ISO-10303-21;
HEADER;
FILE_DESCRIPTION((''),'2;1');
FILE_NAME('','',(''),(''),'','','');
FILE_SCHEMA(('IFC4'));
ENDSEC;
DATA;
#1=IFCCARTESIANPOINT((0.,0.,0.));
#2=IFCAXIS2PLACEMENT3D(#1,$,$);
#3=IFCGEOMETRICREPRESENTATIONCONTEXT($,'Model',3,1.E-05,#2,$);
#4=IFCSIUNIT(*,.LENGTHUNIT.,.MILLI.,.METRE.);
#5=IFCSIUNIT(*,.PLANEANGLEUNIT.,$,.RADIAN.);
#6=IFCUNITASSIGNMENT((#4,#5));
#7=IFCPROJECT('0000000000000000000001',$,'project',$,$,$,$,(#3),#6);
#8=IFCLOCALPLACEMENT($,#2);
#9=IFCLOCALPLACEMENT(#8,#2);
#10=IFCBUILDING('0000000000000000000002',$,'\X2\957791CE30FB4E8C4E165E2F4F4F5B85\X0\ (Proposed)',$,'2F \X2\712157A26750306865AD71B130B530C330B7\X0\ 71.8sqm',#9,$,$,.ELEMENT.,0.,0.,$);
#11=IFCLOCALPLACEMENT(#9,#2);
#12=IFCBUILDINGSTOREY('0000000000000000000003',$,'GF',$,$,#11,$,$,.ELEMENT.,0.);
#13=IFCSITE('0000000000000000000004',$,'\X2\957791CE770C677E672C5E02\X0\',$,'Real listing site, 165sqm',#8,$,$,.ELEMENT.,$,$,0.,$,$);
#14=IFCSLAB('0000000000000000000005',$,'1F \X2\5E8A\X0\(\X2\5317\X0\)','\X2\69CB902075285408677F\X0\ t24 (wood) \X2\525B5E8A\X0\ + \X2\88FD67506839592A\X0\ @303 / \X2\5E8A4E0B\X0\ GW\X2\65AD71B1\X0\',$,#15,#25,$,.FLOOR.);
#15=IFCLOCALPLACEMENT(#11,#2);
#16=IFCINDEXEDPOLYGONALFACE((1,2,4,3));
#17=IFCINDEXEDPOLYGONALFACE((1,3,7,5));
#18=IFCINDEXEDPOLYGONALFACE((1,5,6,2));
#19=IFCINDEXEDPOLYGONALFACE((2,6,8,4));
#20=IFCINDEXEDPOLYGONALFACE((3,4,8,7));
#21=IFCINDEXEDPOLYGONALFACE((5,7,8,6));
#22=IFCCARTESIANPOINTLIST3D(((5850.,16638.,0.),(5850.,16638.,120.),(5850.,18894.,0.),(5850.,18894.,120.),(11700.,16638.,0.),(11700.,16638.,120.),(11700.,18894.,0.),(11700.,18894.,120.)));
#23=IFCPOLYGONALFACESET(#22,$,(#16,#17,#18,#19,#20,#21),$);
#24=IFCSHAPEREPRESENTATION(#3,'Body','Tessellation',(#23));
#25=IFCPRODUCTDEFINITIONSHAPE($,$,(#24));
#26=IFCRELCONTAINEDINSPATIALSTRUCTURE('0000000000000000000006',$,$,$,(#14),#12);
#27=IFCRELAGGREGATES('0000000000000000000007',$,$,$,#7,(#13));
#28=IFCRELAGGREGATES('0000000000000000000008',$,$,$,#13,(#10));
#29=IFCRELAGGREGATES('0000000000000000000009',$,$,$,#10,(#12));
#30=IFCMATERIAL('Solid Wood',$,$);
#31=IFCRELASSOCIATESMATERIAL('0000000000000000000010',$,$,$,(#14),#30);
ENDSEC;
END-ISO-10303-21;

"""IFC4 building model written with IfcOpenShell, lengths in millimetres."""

from ifc_helpers import new_model, si_unit, frame, frame_2d, origin, place, context, project, spatial, rectangle, extrude, material, element, save


model = new_model("IFC4")

# Units and contexts
model_context = context("Model", 3, precision=1e-05, world=origin())
ifc_project = project(units=[si_unit("LENGTHUNIT", "METRE", prefix="MILLI"), si_unit("PLANEANGLEUNIT", "RADIAN")], contexts=[model_context])

# Site, building, storey
site_placement = place(None, origin())
site = spatial("IfcSite", under=ifc_project, at=site_placement, Name="長野県松本市", ObjectType="Real listing site, 165sqm", CompositionType="ELEMENT", RefElevation=0.0)
building_placement = place(site_placement, origin())
building = spatial("IfcBuilding", under=site, at=building_placement, Name="長野・二世帯住宅 (Proposed)", ObjectType="2F 無垢材と断熱サッシ 71.8sqm", CompositionType="ELEMENT", ElevationOfRefHeight=0.0, ElevationOfTerrain=0.0)
storey_placement = place(building_placement, origin())
storey = spatial("IfcBuildingStorey", under=building, at=storey_placement, Name="GF", CompositionType="ELEMENT", Elevation=0.0)

# Shared definitions
ifc_material_1 = material(Name="Solid Wood")

# Slab
slab_placement = place(storey_placement, frame((2925.0, 8319.0, 0.0)))
element("IfcSlab", 1, at=slab_placement, inside=storey, material=ifc_material_1, Name="1F 床(北)", Description="構造用合板 t24 (wood) 剛床 + 製材根太 @303 / 床下 GW断熱", PredefinedType="FLOOR", context=model_context, shape_type="SweptSolid", body=[
    extrude(rectangle(XDim=5850.0, YDim=2256.0, at=frame_2d((2925.0, 1128.0))), frame((2925.0, 8319.0, 0.0)), (0.0, 0.0, 1.0), 120.0),
])

save(model, "model.ifc")
